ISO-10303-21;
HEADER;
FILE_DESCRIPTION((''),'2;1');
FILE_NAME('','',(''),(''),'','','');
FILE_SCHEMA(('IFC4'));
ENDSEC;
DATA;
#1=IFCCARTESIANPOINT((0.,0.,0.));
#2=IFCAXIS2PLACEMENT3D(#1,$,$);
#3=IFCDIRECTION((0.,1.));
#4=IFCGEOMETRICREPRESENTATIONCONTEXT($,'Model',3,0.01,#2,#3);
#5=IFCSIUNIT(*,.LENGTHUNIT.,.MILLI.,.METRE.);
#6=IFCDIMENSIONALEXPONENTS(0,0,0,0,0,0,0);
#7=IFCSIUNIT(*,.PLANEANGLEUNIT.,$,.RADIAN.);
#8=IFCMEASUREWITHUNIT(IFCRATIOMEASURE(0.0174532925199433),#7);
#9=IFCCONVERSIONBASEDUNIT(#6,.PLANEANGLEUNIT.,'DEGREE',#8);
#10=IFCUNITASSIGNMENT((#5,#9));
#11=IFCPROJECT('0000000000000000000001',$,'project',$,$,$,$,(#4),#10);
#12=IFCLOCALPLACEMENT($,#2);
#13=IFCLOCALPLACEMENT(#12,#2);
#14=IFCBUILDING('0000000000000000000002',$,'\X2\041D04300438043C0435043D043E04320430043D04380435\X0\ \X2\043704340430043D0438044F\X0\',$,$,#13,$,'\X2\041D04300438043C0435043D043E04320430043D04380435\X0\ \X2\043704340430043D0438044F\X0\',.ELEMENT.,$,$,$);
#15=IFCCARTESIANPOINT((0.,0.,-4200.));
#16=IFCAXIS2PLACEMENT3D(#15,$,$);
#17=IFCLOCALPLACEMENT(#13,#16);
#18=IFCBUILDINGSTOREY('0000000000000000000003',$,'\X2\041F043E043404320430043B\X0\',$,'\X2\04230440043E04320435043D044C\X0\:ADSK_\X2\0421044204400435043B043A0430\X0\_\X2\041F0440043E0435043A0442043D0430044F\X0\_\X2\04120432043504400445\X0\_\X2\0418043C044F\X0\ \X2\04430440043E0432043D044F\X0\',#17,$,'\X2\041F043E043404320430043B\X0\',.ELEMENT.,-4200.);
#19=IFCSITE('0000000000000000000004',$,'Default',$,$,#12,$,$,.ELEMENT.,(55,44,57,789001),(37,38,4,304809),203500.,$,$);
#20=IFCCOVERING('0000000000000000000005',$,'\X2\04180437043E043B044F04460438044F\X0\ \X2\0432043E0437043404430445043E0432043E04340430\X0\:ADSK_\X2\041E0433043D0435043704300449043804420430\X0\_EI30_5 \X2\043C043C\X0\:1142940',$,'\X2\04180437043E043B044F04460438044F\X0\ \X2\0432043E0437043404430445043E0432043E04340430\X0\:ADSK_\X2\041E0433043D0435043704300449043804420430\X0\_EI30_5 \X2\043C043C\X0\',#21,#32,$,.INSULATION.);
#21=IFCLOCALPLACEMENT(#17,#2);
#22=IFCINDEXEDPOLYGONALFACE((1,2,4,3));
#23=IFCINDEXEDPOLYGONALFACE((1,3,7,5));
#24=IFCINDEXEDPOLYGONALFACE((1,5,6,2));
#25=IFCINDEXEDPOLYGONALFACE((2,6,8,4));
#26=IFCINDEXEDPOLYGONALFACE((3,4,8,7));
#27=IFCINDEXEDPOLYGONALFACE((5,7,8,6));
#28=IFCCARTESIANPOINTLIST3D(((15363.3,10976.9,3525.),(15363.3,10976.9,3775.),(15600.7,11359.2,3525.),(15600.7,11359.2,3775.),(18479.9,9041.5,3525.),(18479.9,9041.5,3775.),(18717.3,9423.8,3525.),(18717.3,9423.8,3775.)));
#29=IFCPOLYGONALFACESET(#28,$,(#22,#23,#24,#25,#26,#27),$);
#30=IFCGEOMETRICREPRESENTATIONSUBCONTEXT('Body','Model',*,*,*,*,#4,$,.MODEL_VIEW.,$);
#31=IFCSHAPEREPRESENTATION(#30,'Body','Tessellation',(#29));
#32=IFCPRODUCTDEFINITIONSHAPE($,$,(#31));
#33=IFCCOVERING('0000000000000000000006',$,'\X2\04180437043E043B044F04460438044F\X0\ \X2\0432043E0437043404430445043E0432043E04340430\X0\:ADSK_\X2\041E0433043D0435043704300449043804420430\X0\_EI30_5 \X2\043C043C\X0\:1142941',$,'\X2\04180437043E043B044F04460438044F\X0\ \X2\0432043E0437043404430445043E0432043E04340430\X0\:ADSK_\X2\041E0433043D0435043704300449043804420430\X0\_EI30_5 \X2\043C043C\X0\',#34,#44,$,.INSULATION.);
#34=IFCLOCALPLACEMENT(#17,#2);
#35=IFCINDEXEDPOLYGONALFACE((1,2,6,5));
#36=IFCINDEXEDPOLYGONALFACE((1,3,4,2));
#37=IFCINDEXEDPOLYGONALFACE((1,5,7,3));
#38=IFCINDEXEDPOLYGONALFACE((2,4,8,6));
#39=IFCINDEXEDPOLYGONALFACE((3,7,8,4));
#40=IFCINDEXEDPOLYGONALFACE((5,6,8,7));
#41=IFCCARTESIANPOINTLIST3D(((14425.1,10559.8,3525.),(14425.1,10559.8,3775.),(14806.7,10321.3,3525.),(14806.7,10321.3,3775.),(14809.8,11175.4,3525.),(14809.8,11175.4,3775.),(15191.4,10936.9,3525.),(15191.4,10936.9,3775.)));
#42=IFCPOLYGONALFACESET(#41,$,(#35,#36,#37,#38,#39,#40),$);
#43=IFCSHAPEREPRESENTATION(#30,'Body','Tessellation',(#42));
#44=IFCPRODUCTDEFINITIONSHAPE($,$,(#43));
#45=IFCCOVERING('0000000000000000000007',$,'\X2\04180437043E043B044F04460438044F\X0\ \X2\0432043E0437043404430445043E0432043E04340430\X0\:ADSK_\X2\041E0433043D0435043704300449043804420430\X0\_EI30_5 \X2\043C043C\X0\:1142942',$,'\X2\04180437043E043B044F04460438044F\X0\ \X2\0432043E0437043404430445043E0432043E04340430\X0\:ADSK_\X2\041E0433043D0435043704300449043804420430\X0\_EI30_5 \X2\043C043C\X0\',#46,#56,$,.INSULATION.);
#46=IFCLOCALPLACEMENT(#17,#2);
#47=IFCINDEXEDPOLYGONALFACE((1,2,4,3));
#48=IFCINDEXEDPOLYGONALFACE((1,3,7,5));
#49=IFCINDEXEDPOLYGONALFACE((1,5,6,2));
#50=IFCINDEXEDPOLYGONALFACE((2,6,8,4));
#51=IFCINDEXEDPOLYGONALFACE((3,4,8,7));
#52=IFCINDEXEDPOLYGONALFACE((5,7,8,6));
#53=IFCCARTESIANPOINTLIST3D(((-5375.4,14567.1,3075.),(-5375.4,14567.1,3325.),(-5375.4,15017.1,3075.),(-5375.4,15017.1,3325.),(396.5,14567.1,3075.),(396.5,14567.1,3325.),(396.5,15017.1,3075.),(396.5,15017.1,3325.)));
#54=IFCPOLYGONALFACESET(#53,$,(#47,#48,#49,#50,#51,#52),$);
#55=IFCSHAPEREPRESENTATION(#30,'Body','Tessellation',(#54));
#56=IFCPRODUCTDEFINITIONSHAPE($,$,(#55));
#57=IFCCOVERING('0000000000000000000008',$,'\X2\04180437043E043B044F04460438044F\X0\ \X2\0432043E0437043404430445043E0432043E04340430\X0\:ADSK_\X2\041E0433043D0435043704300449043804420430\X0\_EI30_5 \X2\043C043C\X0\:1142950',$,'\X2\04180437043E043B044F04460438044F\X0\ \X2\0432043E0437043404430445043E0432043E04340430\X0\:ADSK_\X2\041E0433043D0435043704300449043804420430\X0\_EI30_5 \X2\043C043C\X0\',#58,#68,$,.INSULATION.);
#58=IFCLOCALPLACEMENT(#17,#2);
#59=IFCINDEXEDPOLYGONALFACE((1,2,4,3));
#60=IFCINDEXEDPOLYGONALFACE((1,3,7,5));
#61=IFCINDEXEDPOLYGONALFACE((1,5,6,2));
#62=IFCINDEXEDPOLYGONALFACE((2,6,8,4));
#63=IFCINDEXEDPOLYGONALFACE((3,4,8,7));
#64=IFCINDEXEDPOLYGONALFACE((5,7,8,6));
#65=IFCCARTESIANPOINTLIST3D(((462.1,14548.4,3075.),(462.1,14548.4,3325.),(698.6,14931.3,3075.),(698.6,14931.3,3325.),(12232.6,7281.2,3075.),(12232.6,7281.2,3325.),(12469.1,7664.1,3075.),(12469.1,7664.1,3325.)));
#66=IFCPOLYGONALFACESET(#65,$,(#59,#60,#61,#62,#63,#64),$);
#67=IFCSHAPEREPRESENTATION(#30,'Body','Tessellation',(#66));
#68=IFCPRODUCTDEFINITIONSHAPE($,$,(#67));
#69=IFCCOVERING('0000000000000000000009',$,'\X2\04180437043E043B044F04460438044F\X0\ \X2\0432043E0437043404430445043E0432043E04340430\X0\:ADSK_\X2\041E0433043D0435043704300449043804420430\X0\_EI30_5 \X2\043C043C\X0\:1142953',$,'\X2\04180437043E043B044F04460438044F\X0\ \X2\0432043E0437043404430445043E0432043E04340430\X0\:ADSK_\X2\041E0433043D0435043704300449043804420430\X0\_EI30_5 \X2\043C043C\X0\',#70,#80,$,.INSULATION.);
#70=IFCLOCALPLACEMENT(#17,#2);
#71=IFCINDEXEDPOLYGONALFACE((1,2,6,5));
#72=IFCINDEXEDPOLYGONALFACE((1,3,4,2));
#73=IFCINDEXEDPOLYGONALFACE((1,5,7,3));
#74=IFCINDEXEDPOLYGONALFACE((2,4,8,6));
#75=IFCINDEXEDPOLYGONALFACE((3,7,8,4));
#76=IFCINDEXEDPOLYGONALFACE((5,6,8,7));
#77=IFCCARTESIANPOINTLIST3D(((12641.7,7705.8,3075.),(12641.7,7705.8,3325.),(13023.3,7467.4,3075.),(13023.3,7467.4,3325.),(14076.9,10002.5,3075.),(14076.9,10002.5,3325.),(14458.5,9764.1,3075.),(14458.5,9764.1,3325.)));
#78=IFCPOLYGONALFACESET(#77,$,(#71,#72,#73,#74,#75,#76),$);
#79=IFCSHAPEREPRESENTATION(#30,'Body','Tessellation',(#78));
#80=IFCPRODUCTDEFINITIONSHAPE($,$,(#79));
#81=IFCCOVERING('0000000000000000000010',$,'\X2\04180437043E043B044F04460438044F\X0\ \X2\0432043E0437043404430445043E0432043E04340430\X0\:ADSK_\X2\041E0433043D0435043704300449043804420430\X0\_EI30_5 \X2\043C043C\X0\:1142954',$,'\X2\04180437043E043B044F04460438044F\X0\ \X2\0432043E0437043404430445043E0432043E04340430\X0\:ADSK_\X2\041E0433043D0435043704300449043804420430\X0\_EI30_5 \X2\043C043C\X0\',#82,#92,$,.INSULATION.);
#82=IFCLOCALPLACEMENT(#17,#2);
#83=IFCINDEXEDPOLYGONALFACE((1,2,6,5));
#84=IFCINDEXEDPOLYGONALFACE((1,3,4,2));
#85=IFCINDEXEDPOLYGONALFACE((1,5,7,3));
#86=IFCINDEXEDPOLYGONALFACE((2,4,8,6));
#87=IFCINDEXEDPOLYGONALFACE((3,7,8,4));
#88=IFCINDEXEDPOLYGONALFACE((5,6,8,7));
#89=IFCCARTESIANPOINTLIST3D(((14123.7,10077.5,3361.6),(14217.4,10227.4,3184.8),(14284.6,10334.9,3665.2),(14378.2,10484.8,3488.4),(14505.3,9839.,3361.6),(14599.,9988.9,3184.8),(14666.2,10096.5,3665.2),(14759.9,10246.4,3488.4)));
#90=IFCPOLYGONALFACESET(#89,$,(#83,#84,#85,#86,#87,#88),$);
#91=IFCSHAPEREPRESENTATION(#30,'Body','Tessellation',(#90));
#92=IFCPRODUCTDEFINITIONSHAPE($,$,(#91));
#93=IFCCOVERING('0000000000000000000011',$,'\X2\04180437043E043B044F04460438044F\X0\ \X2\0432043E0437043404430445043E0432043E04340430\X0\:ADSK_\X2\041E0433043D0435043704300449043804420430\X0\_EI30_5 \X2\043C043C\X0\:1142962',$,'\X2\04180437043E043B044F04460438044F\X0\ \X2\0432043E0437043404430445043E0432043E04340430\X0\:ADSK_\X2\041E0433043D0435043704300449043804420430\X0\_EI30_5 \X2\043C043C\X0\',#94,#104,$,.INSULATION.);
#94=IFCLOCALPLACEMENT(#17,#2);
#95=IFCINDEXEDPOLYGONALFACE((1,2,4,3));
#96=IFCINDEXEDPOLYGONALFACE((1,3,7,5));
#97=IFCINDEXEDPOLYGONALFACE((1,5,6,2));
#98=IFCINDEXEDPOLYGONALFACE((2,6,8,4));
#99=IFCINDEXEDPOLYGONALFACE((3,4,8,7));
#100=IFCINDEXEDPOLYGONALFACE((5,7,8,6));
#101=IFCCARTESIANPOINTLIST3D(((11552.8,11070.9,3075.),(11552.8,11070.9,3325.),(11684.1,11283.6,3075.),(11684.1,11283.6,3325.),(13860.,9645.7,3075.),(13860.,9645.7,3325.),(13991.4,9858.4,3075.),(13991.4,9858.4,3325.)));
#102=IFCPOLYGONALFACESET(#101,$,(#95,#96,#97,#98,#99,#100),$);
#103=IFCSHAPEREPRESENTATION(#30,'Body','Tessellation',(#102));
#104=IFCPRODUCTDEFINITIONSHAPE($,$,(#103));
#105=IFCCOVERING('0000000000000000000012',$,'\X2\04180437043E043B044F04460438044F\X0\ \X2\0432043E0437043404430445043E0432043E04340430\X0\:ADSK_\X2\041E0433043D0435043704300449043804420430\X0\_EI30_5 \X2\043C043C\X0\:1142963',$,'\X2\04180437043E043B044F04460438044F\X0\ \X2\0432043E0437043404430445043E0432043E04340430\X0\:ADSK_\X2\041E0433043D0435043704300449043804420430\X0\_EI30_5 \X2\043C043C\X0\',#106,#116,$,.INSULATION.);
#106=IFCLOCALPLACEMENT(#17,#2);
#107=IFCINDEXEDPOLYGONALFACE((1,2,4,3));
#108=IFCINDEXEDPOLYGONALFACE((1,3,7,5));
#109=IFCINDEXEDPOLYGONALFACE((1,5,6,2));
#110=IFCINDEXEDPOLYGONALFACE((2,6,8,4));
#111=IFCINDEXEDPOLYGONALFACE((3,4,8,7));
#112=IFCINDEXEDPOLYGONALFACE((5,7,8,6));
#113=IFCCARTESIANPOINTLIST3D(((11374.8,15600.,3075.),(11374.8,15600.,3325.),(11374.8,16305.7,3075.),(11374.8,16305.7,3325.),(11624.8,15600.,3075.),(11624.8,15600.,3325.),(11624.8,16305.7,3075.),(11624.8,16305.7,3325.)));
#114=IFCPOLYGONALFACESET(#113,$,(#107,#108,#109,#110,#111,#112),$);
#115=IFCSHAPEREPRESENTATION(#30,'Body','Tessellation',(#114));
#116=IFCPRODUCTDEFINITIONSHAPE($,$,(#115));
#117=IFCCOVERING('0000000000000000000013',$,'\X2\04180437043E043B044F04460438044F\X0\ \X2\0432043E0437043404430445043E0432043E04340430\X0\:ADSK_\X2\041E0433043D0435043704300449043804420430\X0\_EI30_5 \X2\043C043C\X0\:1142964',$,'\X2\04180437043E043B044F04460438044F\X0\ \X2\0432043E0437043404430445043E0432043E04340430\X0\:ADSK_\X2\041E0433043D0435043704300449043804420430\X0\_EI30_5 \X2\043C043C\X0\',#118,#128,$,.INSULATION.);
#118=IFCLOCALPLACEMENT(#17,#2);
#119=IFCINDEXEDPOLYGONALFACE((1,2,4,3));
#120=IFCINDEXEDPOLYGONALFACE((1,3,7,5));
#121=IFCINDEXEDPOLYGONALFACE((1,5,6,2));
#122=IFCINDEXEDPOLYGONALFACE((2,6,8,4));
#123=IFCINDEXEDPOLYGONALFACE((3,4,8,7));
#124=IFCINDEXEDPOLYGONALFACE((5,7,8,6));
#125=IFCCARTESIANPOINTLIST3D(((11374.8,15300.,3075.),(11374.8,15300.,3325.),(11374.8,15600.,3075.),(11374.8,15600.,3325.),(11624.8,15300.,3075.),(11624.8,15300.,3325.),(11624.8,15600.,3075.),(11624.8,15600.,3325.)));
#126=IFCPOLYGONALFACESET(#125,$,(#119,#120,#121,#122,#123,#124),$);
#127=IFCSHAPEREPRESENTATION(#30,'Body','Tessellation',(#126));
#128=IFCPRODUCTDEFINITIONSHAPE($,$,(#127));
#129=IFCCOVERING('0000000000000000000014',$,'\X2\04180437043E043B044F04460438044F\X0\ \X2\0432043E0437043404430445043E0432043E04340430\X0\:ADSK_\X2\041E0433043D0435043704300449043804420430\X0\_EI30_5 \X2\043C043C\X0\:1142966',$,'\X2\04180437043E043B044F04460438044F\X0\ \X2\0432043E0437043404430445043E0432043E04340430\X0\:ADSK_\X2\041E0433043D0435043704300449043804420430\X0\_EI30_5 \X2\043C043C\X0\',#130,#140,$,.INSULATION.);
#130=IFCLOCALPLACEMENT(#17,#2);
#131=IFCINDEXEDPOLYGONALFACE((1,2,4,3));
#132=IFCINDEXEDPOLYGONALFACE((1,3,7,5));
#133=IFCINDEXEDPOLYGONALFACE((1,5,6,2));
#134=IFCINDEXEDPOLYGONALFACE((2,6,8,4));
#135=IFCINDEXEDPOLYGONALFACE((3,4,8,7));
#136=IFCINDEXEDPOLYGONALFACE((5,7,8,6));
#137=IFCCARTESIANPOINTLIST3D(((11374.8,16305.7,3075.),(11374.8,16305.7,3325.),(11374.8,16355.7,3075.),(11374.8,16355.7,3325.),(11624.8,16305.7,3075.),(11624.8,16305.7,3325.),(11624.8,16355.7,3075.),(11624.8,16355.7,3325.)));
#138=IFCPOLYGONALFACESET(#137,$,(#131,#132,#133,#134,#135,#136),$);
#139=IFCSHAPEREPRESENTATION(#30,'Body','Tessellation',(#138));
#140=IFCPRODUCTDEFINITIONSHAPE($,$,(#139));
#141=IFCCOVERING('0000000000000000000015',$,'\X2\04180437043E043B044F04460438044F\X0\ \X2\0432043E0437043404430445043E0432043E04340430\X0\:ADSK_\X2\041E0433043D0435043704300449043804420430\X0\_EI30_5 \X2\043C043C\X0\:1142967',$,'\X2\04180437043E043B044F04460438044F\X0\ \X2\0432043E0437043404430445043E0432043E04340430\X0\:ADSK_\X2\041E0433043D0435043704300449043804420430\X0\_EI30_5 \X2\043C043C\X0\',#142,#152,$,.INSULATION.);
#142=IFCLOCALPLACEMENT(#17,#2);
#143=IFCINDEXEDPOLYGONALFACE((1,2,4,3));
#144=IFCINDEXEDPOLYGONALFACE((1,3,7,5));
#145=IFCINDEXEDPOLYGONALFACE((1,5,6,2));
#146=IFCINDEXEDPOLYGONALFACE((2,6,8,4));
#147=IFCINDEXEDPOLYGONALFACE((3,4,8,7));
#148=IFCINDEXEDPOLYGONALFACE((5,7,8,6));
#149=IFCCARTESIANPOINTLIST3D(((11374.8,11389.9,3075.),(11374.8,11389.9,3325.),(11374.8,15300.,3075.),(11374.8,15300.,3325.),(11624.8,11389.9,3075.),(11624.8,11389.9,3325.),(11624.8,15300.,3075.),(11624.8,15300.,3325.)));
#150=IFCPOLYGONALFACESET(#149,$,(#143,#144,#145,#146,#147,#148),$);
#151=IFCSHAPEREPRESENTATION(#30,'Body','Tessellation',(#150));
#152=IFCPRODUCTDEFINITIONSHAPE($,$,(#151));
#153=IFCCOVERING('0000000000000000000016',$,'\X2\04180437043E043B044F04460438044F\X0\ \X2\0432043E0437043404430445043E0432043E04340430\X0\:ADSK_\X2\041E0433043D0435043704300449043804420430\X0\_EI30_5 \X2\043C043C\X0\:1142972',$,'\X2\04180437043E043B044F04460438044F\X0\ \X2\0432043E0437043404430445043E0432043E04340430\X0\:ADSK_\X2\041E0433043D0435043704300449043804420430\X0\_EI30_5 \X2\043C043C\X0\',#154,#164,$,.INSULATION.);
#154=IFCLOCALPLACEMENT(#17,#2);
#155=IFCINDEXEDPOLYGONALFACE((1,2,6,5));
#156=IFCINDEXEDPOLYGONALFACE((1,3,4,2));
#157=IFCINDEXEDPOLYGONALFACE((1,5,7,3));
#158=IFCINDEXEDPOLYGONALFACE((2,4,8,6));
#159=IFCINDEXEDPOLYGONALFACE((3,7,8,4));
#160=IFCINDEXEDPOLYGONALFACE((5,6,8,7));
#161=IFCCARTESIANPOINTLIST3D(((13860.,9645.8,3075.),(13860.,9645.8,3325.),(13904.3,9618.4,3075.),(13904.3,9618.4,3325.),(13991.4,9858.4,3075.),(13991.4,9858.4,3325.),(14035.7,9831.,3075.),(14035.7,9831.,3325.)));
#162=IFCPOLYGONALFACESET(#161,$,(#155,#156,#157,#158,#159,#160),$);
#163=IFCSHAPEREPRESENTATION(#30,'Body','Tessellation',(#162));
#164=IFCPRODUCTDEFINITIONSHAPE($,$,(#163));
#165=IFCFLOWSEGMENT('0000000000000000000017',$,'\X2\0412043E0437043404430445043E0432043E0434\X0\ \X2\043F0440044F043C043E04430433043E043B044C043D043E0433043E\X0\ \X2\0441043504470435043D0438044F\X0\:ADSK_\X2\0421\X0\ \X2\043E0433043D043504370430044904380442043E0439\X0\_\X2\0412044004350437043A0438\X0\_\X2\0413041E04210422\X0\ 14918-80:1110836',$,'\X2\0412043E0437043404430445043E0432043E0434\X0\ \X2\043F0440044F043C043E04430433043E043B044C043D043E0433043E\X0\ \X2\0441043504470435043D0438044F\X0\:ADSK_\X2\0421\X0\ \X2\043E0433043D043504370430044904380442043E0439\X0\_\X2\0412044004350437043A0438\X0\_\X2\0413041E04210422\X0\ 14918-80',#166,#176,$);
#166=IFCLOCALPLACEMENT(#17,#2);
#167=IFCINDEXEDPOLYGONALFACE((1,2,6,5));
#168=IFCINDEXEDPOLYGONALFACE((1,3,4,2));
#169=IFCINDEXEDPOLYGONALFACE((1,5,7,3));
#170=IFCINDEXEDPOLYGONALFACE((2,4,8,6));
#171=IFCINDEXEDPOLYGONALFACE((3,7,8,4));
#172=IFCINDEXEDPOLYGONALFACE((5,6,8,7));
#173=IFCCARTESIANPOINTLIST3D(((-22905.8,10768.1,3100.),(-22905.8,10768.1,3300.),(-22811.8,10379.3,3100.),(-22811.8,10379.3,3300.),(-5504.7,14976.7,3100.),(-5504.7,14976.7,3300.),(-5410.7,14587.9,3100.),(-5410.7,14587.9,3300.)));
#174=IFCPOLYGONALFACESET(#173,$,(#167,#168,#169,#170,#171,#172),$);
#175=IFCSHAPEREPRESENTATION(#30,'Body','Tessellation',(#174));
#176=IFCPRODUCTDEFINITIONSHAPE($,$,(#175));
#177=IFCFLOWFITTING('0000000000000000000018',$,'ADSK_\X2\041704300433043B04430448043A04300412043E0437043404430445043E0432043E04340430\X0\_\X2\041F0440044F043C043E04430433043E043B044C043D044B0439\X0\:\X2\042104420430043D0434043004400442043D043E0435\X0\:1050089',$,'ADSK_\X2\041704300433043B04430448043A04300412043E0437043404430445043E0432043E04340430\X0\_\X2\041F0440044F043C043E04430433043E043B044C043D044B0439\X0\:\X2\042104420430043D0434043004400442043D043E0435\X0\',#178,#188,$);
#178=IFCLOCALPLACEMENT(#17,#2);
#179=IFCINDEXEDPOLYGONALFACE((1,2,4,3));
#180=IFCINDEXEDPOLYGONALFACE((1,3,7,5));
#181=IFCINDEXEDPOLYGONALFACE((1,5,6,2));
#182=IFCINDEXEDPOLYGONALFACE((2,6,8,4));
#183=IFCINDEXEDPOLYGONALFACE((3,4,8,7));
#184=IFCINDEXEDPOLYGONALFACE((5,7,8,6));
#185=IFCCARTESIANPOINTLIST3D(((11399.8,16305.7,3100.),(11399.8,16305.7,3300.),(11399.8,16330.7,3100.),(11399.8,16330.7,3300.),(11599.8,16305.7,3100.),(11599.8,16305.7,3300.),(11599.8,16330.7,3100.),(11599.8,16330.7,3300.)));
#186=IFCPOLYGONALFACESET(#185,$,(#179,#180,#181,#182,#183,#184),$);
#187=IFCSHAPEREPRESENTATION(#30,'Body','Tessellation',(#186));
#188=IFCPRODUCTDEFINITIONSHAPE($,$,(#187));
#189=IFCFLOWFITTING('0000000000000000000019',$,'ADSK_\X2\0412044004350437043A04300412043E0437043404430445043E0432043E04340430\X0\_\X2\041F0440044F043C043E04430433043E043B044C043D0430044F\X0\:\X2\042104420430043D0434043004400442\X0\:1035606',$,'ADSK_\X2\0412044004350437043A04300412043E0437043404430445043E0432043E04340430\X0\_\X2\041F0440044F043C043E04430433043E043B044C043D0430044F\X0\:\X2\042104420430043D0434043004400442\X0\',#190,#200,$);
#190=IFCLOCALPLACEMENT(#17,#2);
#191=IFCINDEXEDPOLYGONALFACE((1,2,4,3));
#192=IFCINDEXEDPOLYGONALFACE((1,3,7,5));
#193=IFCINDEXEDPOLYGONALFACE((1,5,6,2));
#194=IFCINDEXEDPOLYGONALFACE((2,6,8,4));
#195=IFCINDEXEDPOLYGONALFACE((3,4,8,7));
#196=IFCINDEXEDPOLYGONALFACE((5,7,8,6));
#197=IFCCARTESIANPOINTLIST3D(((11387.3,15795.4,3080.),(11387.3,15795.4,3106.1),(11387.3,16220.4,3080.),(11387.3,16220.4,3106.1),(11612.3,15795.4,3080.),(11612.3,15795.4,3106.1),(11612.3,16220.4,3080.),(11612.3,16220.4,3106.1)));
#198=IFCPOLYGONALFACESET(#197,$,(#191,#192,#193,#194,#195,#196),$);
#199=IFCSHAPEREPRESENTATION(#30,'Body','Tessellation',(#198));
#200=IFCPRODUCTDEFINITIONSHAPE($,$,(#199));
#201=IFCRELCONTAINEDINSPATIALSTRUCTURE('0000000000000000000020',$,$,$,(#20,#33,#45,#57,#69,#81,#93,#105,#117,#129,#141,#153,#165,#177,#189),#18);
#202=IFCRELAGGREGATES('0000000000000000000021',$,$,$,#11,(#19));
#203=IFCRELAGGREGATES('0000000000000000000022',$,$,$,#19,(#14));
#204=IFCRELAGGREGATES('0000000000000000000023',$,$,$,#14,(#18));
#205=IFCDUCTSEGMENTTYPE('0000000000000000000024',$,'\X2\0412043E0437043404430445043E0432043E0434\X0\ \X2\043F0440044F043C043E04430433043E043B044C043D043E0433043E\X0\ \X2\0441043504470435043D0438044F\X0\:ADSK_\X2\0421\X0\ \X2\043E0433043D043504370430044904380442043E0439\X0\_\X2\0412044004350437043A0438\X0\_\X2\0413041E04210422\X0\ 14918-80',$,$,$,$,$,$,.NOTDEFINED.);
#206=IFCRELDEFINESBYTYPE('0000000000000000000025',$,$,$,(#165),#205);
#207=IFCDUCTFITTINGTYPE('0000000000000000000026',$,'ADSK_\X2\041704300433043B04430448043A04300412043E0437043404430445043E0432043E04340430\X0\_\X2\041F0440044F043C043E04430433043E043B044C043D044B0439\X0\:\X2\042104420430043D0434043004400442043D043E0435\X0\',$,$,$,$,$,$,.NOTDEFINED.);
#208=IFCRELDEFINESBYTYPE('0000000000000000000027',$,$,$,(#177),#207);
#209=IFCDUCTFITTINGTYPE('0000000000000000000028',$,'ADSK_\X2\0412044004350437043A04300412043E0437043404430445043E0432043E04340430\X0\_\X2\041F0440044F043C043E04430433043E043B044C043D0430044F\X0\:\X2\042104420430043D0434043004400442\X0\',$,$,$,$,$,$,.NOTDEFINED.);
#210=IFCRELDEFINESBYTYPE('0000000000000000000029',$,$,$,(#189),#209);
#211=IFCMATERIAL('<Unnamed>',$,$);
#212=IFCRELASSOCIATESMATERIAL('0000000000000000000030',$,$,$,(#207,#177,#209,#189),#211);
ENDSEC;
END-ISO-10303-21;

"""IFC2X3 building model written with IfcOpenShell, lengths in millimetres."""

from ifc_helpers import new_model, entity, si_unit, converted_unit, direction, frame, origin, origin_2d_with_axis, place, context, subcontext, project, spatial, rectangle, extrude, source, transform, mapped, material, type_object, type_shapes, element, save


model = new_model("IFC2X3")

# Units and contexts
model_context = context("Model", 3, precision=0.01, world=origin(), true_north=direction((0.0, 1.0)))
body_context = subcontext(model_context, "Body", "Model", "MODEL_VIEW")
ifc_project = project(units=[si_unit("LENGTHUNIT", "METRE", prefix="MILLI"), converted_unit("PLANEANGLEUNIT", "DEGREE", entity("IfcRatioMeasure", 0.0174532925199433), si_unit("PLANEANGLEUNIT", "RADIAN"), dimensions=[0, 0, 0, 0, 0, 0, 0])], contexts=[model_context])

# Site, building, storey
site_placement = place(None, origin())
site = spatial("IfcSite", under=ifc_project, at=site_placement, Name="Default", CompositionType="ELEMENT", RefLatitude=(55, 44, 57, 789001), RefLongitude=(37, 38, 4, 304809), RefElevation=203500.0)
building_placement = place(site_placement, origin())
building = spatial("IfcBuilding", under=site, at=building_placement, Name="Наименование здания", LongName="Наименование здания", CompositionType="ELEMENT")
storey_placement = place(building_placement, frame((0.0, 0.0, -4200.0)))
storey = spatial("IfcBuildingStorey", under=building, at=storey_placement, Name="Подвал", ObjectType="Уровень:ADSK_Стрелка_Проектная_Вверх_Имя уровня", LongName="Подвал", CompositionType="ELEMENT", Elevation=-4200.0)

# Coverings
covering_1_placement = place(storey_placement, frame((15363.3, 9041.5, 3525.0)))
element("IfcCovering", 1, at=covering_1_placement, inside=storey, Name="Изоляция воздуховода:ADSK_Огнезащита_EI30_5 мм:1142940", ObjectType="Изоляция воздуховода:ADSK_Огнезащита_EI30_5 мм", PredefinedType="INSULATION", context=body_context, shape_type="SweptSolid", body=[
    extrude(rectangle(XDim=3668.6, YDim=450.0, at=origin_2d_with_axis()), frame((1677.0, 1158.8, 0.0), z_axis=(0.0, 0.0, 1.0), x_axis=(-0.849526, 0.527546, 0.0)), (0.0, 0.0, 1.0), 250.0),
])
covering_2_placement = place(storey_placement, frame((14425.1, 10321.3, 3525.0)))
element("IfcCovering", 2, at=covering_2_placement, inside=storey, Name="Изоляция воздуховода:ADSK_Огнезащита_EI30_5 мм:1142941", ObjectType="Изоляция воздуховода:ADSK_Огнезащита_EI30_5 мм", PredefinedType="INSULATION", context=body_context, shape_type="SweptSolid", body=[
    extrude(rectangle(XDim=725.9, YDim=450.0, at=origin_2d_with_axis()), frame((383.1, 427.0, 0.0), z_axis=(0.0, 0.0, 1.0), x_axis=(-0.529919, -0.848048, 0.0)), (0.0, 0.0, 1.0), 250.0),
])
covering_3_placement = place(storey_placement, frame((-5375.4, 14567.1, 3075.0)))
element("IfcCovering", 3, at=covering_3_placement, inside=storey, Name="Изоляция воздуховода:ADSK_Огнезащита_EI30_5 мм:1142942", ObjectType="Изоляция воздуховода:ADSK_Огнезащита_EI30_5 мм", PredefinedType="INSULATION", context=body_context, shape_type="SweptSolid", body=[
    extrude(rectangle(XDim=5771.9, YDim=450.0, at=origin_2d_with_axis()), frame((2885.9, 225.0, 0.0)), (0.0, 0.0, 1.0), 250.0),
])
covering_4_placement = place(storey_placement, frame((462.1, 7281.2, 3075.0)))
element("IfcCovering", 4, at=covering_4_placement, inside=storey, Name="Изоляция воздуховода:ADSK_Огнезащита_EI30_5 мм:1142950", ObjectType="Изоляция воздуховода:ADSK_Огнезащита_EI30_5 мм", PredefinedType="INSULATION", context=body_context, shape_type="SweptSolid", body=[
    extrude(rectangle(XDim=13833.2, YDim=450.0, at=origin_2d_with_axis()), frame((6003.5, 3825.1, 0.0), z_axis=(0.0, 0.0, 1.0), x_axis=(0.850888, -0.525347, 0.0)), (0.0, 0.0, 1.0), 250.0),
])
covering_5_placement = place(storey_placement, frame((12641.7, 7467.4, 3075.0)))
element("IfcCovering", 5, at=covering_5_placement, inside=storey, Name="Изоляция воздуховода:ADSK_Огнезащита_EI30_5 мм:1142953", ObjectType="Изоляция воздуховода:ADSK_Огнезащита_EI30_5 мм", PredefinedType="INSULATION", context=body_context, shape_type="SweptSolid", body=[
    extrude(rectangle(XDim=2708.2, YDim=450.0, at=origin_2d_with_axis()), frame((908.4, 1267.6, 0.0), z_axis=(0.0, 0.0, 1.0), x_axis=(0.529919, 0.848048, 0.0)), (0.0, 0.0, 1.0), 250.0),
])
covering_6_placement = place(storey_placement, frame((14123.7, 9839.0, 3184.8)))
element("IfcCovering", 6, at=covering_6_placement, inside=storey, Name="Изоляция воздуховода:ADSK_Огнезащита_EI30_5 мм:1142954", ObjectType="Изоляция воздуховода:ADSK_Огнезащита_EI30_5 мм", PredefinedType="INSULATION", context=body_context, shape_type="SweptSolid", body=[
    extrude(rectangle(XDim=429.3, YDim=250.0, at=origin_2d_with_axis()), frame((127.3, 442.1, 240.2), z_axis=(0.848048, -0.529919, 0.0), x_axis=(0.37471, 0.599661, 0.707107)), (0.0, 0.0, 1.0), 450.0),
])
covering_7_placement = place(storey_placement, frame((11552.8, 9645.8, 3075.0)))
element("IfcCovering", 7, at=covering_7_placement, inside=storey, Name="Изоляция воздуховода:ADSK_Огнезащита_EI30_5 мм:1142962", ObjectType="Изоляция воздуховода:ADSK_Огнезащита_EI30_5 мм", PredefinedType="INSULATION", context=body_context, shape_type="SweptSolid", body=[
    extrude(rectangle(XDim=2711.9, YDim=250.0, at=origin_2d_with_axis()), frame((1219.3, 818.9, 0.0), z_axis=(0.0, 0.0, 1.0), x_axis=(0.850783, -0.525517, 0.0)), (0.0, 0.0, 1.0), 250.0),
])
covering_8_placement = place(storey_placement, frame((11374.8, 15600.0, 3075.0)))
element("IfcCovering", 8, at=covering_8_placement, inside=storey, Name="Изоляция воздуховода:ADSK_Огнезащита_EI30_5 мм:1142963", ObjectType="Изоляция воздуховода:ADSK_Огнезащита_EI30_5 мм", PredefinedType="INSULATION", context=body_context, shape_type="SweptSolid", body=[
    extrude(rectangle(XDim=705.7, YDim=250.0, at=origin_2d_with_axis()), frame((125.0, 352.9, 0.0), z_axis=(0.0, 0.0, 1.0), x_axis=(0.0, 1.0, 0.0)), (0.0, 0.0, 1.0), 250.0),
])
covering_9_placement = place(storey_placement, frame((11374.8, 15300.0, 3075.0)))
element("IfcCovering", 9, at=covering_9_placement, inside=storey, Name="Изоляция воздуховода:ADSK_Огнезащита_EI30_5 мм:1142964", ObjectType="Изоляция воздуховода:ADSK_Огнезащита_EI30_5 мм", PredefinedType="INSULATION", context=body_context, shape_type="SweptSolid", body=[
    extrude(rectangle(XDim=300.0, YDim=250.0, at=origin_2d_with_axis()), frame((125.0, 150.0, 0.0), z_axis=(0.0, 0.0, 1.0), x_axis=(0.0, 1.0, 0.0)), (0.0, 0.0, 1.0), 250.0),
])
covering_10_placement = place(storey_placement, frame((11374.8, 16305.7, 3075.0)))
element("IfcCovering", 10, at=covering_10_placement, inside=storey, Name="Изоляция воздуховода:ADSK_Огнезащита_EI30_5 мм:1142966", ObjectType="Изоляция воздуховода:ADSK_Огнезащита_EI30_5 мм", PredefinedType="INSULATION", context=body_context, shape_type="SweptSolid", body=[
    extrude(rectangle(XDim=50.0, YDim=250.0, at=origin_2d_with_axis()), frame((125.0, 25.0, 0.0), z_axis=(0.0, 0.0, 1.0), x_axis=(0.0, -1.0, 0.0)), (0.0, 0.0, 1.0), 250.0),
])
covering_11_placement = place(storey_placement, frame((11374.8, 11389.9, 3075.0)))
element("IfcCovering", 11, at=covering_11_placement, inside=storey, Name="Изоляция воздуховода:ADSK_Огнезащита_EI30_5 мм:1142967", ObjectType="Изоляция воздуховода:ADSK_Огнезащита_EI30_5 мм", PredefinedType="INSULATION", context=body_context, shape_type="SweptSolid", body=[
    extrude(rectangle(XDim=3910.1, YDim=250.0, at=origin_2d_with_axis()), frame((125.0, 1955.0, 0.0), z_axis=(0.0, 0.0, 1.0), x_axis=(0.0, 1.0, 0.0)), (0.0, 0.0, 1.0), 250.0),
])
covering_12_placement = place(storey_placement, frame((13860.0, 9618.4, 3075.0)))
element("IfcCovering", 12, at=covering_12_placement, inside=storey, Name="Изоляция воздуховода:ADSK_Огнезащита_EI30_5 мм:1142972", ObjectType="Изоляция воздуховода:ADSK_Огнезащита_EI30_5 мм", PredefinedType="INSULATION", context=body_context, shape_type="SweptSolid", body=[
    extrude(rectangle(XDim=52.1, YDim=250.0, at=origin_2d_with_axis()), frame((87.9, 120.0, 0.0), z_axis=(0.0, 0.0, 1.0), x_axis=(0.850783, -0.525517, 0.0)), (0.0, 0.0, 1.0), 250.0),
])

# Flow segment
duct_segment_type = type_object("IfcDuctSegmentType", Name="Воздуховод прямоугольного сечения:ADSK_С огнезащитой_Врезки_ГОСТ 14918-80", PredefinedType="NOTDEFINED")
flow_segment_placement = place(storey_placement, frame((-22905.8, 10379.3, 3100.0)))
element("IfcFlowSegment", 13, at=flow_segment_placement, inside=storey, type_object=duct_segment_type, Name="Воздуховод прямоугольного сечения:ADSK_С огнезащитой_Врезки_ГОСТ 14918-80:1110836", ObjectType="Воздуховод прямоугольного сечения:ADSK_С огнезащитой_Врезки_ГОСТ 14918-80", context=body_context, shape_type="SweptSolid", body=[
    extrude(rectangle(XDim=17902.8, YDim=400.0, at=origin_2d_with_axis()), frame((8747.6, 2298.7, 0.0), z_axis=(0.0, 0.0, 1.0), x_axis=(-0.971976, -0.235081, 0.0)), (0.0, 0.0, 1.0), 200.0),
])

# Flow fittings
ifc_material_1 = material(Name="<Unnamed>")
duct_fitting_type_1 = type_object("IfcDuctFittingType", Name="ADSK_ЗаглушкаВоздуховода_Прямоугольный:Стандартное", PredefinedType="NOTDEFINED", material=ifc_material_1)
shared_shape_1 = source(origin(), body_context, "Body", "SweptSolid", [
    extrude(rectangle(XDim=25.0, YDim=200.0, at=origin_2d_with_axis()), frame((12.5, 0.0, -100.0)), (0.0, 0.0, 1.0), 200.0),
])
type_shapes(duct_fitting_type_1, [shared_shape_1])
flow_fitting_1_placement = place(storey_placement, frame((11499.8, 16305.7, 3200.0), z_axis=(0.0, 0.0, 1.0), x_axis=(0.0, 1.0, 0.0)))
element("IfcFlowFitting", 14, at=flow_fitting_1_placement, inside=storey, type_object=duct_fitting_type_1, material=ifc_material_1, Name="ADSK_ЗаглушкаВоздуховода_Прямоугольный:Стандартное:1050089", ObjectType="ADSK_ЗаглушкаВоздуховода_Прямоугольный:Стандартное", context=body_context, shape_type="MappedRepresentation", body=[
    mapped(shared_shape_1, transform((0.0, 0.0, 0.0), scale=1.0)),
])
duct_fitting_type_2 = type_object("IfcDuctFittingType", Name="ADSK_ВрезкаВоздуховода_Прямоугольная:Стандарт", PredefinedType="NOTDEFINED", material=ifc_material_1)
shared_shape_2 = source(origin(), body_context, "Body", "SweptSolid", [
    extrude(rectangle(XDim=225.0, YDim=26.1, at=origin_2d_with_axis()), frame((7.0, 0.0, -212.5), z_axis=(0.0, 0.0, 1.0), x_axis=(0.0, -1.0, 0.0)), (0.0, 0.0, 1.0), 425.0),
])
type_shapes(duct_fitting_type_2, [shared_shape_2])
flow_fitting_2_placement = place(storey_placement, frame((11499.8, 16007.9, 3100.0), z_axis=(0.0, -1.0, 0.0), x_axis=(0.0, 0.0, -1.0)))
element("IfcFlowFitting", 15, at=flow_fitting_2_placement, inside=storey, type_object=duct_fitting_type_2, material=ifc_material_1, Name="ADSK_ВрезкаВоздуховода_Прямоугольная:Стандарт:1035606", ObjectType="ADSK_ВрезкаВоздуховода_Прямоугольная:Стандарт", context=body_context, shape_type="MappedRepresentation", body=[
    mapped(shared_shape_2, transform((0.0, 0.0, 0.0), scale=1.0)),
])

save(model, "model.ifc")
